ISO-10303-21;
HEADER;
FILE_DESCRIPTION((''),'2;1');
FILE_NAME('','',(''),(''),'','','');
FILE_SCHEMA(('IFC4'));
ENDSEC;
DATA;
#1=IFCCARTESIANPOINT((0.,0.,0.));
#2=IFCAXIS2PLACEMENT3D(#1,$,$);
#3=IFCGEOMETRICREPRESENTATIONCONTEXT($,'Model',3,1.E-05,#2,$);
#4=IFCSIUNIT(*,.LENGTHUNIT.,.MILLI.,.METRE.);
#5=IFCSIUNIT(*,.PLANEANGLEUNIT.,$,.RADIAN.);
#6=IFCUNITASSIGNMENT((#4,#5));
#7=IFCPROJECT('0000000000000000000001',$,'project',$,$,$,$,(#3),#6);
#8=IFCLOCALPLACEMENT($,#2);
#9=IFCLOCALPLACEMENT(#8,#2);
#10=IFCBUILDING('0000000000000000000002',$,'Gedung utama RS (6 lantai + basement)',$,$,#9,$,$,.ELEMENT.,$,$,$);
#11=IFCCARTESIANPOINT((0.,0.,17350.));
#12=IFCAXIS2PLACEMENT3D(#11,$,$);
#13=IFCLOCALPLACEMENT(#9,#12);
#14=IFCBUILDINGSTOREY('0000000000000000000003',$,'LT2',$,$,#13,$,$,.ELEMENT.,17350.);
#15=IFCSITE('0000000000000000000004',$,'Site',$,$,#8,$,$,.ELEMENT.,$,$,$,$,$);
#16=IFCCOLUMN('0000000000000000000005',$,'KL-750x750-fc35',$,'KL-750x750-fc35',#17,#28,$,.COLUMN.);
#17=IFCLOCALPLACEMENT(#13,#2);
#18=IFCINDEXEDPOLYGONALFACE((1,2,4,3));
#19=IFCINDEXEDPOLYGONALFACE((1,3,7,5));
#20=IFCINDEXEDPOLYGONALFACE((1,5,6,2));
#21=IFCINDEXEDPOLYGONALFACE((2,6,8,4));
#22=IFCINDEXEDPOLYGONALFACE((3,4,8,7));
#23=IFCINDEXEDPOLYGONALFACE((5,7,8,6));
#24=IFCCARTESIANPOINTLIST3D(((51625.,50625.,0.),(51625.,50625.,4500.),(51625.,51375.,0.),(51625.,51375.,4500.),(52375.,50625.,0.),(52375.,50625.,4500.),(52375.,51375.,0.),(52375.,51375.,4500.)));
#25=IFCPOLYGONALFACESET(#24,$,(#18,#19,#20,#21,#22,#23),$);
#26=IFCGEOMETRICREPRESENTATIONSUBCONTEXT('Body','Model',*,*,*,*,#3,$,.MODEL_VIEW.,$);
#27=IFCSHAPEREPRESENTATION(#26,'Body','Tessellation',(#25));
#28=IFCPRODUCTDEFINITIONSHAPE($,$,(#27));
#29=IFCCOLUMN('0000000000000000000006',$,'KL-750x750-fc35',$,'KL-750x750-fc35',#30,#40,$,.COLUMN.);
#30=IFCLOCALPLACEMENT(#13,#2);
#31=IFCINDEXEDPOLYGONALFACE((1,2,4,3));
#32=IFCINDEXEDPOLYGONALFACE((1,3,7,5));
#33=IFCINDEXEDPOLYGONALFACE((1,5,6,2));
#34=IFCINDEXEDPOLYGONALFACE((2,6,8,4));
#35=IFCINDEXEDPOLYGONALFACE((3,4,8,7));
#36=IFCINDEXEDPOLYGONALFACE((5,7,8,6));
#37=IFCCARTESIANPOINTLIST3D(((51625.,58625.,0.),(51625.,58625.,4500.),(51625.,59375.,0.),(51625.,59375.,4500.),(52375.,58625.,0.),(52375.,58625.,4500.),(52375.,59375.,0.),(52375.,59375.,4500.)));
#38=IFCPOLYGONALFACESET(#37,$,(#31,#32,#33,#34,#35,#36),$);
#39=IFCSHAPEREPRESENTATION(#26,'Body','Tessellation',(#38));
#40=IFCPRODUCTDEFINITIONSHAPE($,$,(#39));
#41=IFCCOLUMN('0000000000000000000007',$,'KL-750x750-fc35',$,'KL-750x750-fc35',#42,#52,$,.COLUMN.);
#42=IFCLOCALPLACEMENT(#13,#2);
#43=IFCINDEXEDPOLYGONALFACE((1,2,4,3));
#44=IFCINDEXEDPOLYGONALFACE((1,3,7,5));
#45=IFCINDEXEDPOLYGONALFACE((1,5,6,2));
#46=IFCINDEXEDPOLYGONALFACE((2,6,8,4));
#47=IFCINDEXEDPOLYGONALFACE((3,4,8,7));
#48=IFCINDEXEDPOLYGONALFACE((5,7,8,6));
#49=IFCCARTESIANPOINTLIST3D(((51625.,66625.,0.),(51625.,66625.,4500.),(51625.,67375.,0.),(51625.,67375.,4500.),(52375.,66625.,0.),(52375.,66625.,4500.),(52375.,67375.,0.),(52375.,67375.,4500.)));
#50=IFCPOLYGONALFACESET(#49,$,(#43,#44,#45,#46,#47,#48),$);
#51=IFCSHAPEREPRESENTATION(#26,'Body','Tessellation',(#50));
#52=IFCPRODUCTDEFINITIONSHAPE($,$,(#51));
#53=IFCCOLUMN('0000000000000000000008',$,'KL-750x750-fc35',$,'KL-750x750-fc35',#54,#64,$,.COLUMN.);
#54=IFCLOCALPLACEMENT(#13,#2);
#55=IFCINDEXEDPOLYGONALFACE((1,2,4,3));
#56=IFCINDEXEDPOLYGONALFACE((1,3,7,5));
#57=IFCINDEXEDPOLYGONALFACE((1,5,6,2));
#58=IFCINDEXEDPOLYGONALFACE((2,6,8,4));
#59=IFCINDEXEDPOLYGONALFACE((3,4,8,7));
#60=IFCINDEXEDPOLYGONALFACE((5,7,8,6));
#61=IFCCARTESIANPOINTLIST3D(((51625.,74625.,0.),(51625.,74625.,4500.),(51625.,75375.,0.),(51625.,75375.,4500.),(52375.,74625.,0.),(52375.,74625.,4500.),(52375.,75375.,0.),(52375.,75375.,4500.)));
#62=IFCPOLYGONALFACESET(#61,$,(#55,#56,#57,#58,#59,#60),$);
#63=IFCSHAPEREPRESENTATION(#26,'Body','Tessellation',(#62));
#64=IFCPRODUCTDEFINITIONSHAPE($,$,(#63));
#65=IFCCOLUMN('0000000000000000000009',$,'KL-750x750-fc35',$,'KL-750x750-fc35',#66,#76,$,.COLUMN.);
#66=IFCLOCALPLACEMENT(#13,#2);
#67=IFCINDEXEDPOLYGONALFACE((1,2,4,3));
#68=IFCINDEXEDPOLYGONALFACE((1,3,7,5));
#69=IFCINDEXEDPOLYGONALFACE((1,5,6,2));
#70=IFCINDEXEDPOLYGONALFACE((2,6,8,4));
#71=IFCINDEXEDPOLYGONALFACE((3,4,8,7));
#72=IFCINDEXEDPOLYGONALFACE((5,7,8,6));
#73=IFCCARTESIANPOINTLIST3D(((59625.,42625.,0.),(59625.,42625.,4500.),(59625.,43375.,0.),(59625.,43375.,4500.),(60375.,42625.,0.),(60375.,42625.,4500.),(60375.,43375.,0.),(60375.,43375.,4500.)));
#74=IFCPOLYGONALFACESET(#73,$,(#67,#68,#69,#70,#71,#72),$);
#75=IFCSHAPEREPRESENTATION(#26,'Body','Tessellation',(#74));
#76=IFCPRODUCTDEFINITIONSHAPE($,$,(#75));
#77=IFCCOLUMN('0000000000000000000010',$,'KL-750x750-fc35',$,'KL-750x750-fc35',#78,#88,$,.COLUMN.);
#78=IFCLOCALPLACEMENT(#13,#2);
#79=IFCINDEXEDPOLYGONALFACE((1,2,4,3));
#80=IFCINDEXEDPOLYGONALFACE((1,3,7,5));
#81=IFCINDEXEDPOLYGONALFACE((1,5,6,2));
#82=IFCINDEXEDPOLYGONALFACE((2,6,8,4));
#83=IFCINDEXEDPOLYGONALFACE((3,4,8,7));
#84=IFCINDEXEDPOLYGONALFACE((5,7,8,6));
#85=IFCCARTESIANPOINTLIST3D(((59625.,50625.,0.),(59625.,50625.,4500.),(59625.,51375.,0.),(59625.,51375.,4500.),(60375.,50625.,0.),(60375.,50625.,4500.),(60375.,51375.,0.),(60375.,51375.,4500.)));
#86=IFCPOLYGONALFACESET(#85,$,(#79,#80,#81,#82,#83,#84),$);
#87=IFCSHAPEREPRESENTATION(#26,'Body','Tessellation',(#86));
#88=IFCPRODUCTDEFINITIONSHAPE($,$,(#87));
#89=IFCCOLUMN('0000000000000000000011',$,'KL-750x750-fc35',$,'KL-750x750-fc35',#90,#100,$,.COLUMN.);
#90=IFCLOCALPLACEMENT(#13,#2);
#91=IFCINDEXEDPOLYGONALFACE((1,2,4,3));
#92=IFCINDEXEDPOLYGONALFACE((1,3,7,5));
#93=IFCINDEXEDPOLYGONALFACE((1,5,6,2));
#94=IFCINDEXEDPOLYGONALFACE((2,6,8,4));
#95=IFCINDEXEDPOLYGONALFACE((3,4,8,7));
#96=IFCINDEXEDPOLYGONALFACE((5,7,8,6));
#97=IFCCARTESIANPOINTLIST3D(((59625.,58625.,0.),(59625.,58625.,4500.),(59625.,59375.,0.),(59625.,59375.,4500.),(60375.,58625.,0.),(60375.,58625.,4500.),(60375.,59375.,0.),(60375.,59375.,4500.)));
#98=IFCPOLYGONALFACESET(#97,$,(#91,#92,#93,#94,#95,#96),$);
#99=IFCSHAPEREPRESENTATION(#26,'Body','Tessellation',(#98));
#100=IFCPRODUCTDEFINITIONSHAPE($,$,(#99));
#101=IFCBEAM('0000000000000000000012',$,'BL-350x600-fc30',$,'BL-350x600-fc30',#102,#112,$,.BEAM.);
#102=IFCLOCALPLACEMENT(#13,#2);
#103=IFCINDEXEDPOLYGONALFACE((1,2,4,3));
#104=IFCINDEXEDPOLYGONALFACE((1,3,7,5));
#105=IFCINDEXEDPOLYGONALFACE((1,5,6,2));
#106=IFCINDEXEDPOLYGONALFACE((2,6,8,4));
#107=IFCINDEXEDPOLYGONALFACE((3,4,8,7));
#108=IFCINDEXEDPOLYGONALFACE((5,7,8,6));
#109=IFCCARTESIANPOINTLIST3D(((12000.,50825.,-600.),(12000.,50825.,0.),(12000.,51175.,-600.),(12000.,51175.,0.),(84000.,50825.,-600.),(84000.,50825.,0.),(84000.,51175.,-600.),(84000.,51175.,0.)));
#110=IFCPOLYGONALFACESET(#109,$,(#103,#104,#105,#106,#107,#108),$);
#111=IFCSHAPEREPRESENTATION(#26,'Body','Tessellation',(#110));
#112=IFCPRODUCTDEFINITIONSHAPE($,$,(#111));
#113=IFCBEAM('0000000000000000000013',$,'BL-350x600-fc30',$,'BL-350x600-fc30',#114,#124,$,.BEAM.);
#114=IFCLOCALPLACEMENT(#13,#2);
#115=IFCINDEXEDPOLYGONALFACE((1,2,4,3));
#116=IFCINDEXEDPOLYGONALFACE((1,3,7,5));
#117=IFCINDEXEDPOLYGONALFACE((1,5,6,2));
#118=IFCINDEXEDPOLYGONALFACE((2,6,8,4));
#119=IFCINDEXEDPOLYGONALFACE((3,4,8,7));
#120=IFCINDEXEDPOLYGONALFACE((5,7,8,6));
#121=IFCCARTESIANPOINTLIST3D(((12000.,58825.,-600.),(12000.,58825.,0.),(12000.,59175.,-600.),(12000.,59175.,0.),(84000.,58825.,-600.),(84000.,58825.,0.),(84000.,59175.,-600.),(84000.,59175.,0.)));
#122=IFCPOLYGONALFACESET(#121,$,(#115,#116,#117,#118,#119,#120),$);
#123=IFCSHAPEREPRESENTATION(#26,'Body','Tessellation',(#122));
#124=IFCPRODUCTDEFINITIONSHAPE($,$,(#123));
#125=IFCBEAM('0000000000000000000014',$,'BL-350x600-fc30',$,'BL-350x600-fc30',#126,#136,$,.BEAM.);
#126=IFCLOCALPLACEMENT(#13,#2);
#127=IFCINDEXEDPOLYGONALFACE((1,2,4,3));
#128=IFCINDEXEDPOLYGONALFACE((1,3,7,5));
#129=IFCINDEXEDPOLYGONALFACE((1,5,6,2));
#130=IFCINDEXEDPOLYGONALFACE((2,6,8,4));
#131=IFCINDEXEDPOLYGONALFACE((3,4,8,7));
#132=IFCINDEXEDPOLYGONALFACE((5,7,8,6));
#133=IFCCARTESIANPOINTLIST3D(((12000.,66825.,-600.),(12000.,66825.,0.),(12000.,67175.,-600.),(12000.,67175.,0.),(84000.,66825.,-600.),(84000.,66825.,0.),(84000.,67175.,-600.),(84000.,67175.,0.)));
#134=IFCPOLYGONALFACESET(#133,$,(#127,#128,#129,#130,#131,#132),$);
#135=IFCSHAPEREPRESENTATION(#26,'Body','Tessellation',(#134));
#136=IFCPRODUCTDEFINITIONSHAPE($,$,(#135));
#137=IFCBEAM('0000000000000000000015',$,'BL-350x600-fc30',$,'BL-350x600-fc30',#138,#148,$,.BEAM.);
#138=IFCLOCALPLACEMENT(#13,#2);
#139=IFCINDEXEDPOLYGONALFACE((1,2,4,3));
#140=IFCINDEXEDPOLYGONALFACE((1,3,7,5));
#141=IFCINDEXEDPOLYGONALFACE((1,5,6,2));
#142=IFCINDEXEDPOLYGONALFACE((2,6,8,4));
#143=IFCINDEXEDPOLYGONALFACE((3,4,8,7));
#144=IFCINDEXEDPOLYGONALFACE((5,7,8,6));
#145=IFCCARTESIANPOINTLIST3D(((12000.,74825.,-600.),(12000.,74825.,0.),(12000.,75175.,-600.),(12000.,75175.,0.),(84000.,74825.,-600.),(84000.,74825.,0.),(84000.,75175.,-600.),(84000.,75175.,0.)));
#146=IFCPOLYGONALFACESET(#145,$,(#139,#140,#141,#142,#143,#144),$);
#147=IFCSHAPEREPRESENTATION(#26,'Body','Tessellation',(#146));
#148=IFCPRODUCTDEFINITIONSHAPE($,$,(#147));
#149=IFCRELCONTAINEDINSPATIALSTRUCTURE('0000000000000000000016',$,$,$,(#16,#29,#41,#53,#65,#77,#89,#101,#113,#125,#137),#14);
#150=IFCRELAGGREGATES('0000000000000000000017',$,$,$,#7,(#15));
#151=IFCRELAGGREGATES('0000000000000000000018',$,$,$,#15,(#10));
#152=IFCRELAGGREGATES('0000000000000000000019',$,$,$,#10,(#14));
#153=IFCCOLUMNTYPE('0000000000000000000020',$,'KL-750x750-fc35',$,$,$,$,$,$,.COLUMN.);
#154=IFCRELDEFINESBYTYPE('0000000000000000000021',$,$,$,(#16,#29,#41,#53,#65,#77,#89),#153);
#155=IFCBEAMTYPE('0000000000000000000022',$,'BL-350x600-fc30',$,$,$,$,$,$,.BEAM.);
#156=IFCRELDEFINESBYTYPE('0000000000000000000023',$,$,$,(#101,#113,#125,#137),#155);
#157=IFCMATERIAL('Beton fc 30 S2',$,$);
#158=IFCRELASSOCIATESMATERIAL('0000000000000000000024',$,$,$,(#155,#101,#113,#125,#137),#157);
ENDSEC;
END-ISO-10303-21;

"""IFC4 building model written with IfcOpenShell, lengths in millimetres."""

from ifc_helpers import new_model, si_unit, frame, origin, origin_2d, place, context, subcontext, project, spatial, rectangle, extrude, material, material_profile, profile_set, profile_usage, type_object, element, save


model = new_model("IFC4")

# Units and contexts
model_context = context("Model", 3, precision=1e-05, world=origin())
body_context = subcontext(model_context, "Body", "Model", "MODEL_VIEW")
ifc_project = project(units=[si_unit("LENGTHUNIT", "METRE", prefix="MILLI"), si_unit("PLANEANGLEUNIT", "RADIAN")], contexts=[model_context])

# Site, building, storey
site_placement = place(None, origin())
site = spatial("IfcSite", under=ifc_project, at=site_placement, Name="Site", CompositionType="ELEMENT")
building_placement = place(site_placement, origin())
building = spatial("IfcBuilding", under=site, at=building_placement, Name="Gedung utama RS (6 lantai + basement)", CompositionType="ELEMENT")
storey_placement = place(building_placement, frame((0.0, 0.0, 17350.0)))
storey = spatial("IfcBuildingStorey", under=building, at=storey_placement, Name="LT2", CompositionType="ELEMENT", Elevation=17350.0)

# Columns
ifc_material_profile_1 = material_profile(None, rectangle(XDim=750.0, YDim=750.0, at=origin_2d()), Name="KL-750x750-fc35")
ifc_profile_set_1 = profile_set([ifc_material_profile_1], Name="KL-750x750-fc35")
ifc_profile_usage_1 = profile_usage(ifc_profile_set_1, cardinal=5)
column_type = type_object("IfcColumnType", Name="KL-750x750-fc35", PredefinedType="COLUMN", material=ifc_profile_set_1)
for number, where, z_axis, x_axis, name in (
    (1, (52000.0, 51000.0, 0.0), (0.0, 0.0, 1.0), (1.0, 0.0, 0.0), "KL-750x750-fc35"),
    (2, (52000.0, 59000.0, 0.0), (0.0, 0.0, 1.0), (1.0, 0.0, 0.0), "KL-750x750-fc35"),
    (3, (52000.0, 67000.0, 0.0), (0.0, 0.0, 1.0), (1.0, 0.0, 0.0), "KL-750x750-fc35"),
    (4, (52000.0, 75000.0, 0.0), (0.0, 0.0, 1.0), (1.0, 0.0, 0.0), "KL-750x750-fc35"),
    (5, (60000.0, 43000.0, 0.0), (0.0, 0.0, 1.0), (1.0, 0.0, 0.0), "KL-750x750-fc35"),
    (6, (60000.0, 51000.0, 0.0), (0.0, 0.0, 1.0), (1.0, 0.0, 0.0), "KL-750x750-fc35"),
    (7, (60000.0, 59000.0, 0.0), (0.0, 0.0, 1.0), (1.0, 0.0, 0.0), "KL-750x750-fc35"),
):
    element("IfcColumn", number, at=place(storey_placement, frame(where, z_axis=z_axis, x_axis=x_axis)), inside=storey, type_object=column_type, material=ifc_profile_usage_1, Name=name, ObjectType="KL-750x750-fc35", PredefinedType="COLUMN", context=body_context, shape_type="SweptSolid", body=[
        extrude(rectangle(XDim=750.0, YDim=750.0, at=origin_2d()), origin(), (0.0, 0.0, 1.0), 4500.0),
    ])

# Beams
ifc_material = material(Name="Beton fc 30 S2")
ifc_material_profile_2 = material_profile(ifc_material, rectangle(XDim=350.0, YDim=600.0, at=origin_2d()), Name="BL-350x600-fc30")
ifc_profile_set_2 = profile_set([ifc_material_profile_2], Name="BL-350x600-fc30")
ifc_profile_usage_2 = profile_usage(ifc_profile_set_2, cardinal=8)
beam_type = type_object("IfcBeamType", Name="BL-350x600-fc30", PredefinedType="BEAM", material=ifc_profile_set_2)
for number, where, name in (
    (8, (12000.0, 51000.0, -300.0), "BL-350x600-fc30"),
    (9, (12000.0, 59000.0, -300.0), "BL-350x600-fc30"),
    (10, (12000.0, 67000.0, -300.0), "BL-350x600-fc30"),
    (11, (12000.0, 75000.0, -300.0), "BL-350x600-fc30"),
):
    element("IfcBeam", number, at=place(storey_placement, frame(where)), inside=storey, type_object=beam_type, material=ifc_profile_usage_2, Name=name, ObjectType="BL-350x600-fc30", PredefinedType="BEAM", context=body_context, shape_type="SweptSolid", body=[
        extrude(rectangle(XDim=350.0, YDim=600.0, at=origin_2d()), frame((0.0, 0.0, 0.0), z_axis=(1.0, 0.0, 0.0), x_axis=(0.0, 1.0, 0.0)), (0.0, 0.0, 1.0), 72000.0),
    ])

save(model, "model.ifc")
